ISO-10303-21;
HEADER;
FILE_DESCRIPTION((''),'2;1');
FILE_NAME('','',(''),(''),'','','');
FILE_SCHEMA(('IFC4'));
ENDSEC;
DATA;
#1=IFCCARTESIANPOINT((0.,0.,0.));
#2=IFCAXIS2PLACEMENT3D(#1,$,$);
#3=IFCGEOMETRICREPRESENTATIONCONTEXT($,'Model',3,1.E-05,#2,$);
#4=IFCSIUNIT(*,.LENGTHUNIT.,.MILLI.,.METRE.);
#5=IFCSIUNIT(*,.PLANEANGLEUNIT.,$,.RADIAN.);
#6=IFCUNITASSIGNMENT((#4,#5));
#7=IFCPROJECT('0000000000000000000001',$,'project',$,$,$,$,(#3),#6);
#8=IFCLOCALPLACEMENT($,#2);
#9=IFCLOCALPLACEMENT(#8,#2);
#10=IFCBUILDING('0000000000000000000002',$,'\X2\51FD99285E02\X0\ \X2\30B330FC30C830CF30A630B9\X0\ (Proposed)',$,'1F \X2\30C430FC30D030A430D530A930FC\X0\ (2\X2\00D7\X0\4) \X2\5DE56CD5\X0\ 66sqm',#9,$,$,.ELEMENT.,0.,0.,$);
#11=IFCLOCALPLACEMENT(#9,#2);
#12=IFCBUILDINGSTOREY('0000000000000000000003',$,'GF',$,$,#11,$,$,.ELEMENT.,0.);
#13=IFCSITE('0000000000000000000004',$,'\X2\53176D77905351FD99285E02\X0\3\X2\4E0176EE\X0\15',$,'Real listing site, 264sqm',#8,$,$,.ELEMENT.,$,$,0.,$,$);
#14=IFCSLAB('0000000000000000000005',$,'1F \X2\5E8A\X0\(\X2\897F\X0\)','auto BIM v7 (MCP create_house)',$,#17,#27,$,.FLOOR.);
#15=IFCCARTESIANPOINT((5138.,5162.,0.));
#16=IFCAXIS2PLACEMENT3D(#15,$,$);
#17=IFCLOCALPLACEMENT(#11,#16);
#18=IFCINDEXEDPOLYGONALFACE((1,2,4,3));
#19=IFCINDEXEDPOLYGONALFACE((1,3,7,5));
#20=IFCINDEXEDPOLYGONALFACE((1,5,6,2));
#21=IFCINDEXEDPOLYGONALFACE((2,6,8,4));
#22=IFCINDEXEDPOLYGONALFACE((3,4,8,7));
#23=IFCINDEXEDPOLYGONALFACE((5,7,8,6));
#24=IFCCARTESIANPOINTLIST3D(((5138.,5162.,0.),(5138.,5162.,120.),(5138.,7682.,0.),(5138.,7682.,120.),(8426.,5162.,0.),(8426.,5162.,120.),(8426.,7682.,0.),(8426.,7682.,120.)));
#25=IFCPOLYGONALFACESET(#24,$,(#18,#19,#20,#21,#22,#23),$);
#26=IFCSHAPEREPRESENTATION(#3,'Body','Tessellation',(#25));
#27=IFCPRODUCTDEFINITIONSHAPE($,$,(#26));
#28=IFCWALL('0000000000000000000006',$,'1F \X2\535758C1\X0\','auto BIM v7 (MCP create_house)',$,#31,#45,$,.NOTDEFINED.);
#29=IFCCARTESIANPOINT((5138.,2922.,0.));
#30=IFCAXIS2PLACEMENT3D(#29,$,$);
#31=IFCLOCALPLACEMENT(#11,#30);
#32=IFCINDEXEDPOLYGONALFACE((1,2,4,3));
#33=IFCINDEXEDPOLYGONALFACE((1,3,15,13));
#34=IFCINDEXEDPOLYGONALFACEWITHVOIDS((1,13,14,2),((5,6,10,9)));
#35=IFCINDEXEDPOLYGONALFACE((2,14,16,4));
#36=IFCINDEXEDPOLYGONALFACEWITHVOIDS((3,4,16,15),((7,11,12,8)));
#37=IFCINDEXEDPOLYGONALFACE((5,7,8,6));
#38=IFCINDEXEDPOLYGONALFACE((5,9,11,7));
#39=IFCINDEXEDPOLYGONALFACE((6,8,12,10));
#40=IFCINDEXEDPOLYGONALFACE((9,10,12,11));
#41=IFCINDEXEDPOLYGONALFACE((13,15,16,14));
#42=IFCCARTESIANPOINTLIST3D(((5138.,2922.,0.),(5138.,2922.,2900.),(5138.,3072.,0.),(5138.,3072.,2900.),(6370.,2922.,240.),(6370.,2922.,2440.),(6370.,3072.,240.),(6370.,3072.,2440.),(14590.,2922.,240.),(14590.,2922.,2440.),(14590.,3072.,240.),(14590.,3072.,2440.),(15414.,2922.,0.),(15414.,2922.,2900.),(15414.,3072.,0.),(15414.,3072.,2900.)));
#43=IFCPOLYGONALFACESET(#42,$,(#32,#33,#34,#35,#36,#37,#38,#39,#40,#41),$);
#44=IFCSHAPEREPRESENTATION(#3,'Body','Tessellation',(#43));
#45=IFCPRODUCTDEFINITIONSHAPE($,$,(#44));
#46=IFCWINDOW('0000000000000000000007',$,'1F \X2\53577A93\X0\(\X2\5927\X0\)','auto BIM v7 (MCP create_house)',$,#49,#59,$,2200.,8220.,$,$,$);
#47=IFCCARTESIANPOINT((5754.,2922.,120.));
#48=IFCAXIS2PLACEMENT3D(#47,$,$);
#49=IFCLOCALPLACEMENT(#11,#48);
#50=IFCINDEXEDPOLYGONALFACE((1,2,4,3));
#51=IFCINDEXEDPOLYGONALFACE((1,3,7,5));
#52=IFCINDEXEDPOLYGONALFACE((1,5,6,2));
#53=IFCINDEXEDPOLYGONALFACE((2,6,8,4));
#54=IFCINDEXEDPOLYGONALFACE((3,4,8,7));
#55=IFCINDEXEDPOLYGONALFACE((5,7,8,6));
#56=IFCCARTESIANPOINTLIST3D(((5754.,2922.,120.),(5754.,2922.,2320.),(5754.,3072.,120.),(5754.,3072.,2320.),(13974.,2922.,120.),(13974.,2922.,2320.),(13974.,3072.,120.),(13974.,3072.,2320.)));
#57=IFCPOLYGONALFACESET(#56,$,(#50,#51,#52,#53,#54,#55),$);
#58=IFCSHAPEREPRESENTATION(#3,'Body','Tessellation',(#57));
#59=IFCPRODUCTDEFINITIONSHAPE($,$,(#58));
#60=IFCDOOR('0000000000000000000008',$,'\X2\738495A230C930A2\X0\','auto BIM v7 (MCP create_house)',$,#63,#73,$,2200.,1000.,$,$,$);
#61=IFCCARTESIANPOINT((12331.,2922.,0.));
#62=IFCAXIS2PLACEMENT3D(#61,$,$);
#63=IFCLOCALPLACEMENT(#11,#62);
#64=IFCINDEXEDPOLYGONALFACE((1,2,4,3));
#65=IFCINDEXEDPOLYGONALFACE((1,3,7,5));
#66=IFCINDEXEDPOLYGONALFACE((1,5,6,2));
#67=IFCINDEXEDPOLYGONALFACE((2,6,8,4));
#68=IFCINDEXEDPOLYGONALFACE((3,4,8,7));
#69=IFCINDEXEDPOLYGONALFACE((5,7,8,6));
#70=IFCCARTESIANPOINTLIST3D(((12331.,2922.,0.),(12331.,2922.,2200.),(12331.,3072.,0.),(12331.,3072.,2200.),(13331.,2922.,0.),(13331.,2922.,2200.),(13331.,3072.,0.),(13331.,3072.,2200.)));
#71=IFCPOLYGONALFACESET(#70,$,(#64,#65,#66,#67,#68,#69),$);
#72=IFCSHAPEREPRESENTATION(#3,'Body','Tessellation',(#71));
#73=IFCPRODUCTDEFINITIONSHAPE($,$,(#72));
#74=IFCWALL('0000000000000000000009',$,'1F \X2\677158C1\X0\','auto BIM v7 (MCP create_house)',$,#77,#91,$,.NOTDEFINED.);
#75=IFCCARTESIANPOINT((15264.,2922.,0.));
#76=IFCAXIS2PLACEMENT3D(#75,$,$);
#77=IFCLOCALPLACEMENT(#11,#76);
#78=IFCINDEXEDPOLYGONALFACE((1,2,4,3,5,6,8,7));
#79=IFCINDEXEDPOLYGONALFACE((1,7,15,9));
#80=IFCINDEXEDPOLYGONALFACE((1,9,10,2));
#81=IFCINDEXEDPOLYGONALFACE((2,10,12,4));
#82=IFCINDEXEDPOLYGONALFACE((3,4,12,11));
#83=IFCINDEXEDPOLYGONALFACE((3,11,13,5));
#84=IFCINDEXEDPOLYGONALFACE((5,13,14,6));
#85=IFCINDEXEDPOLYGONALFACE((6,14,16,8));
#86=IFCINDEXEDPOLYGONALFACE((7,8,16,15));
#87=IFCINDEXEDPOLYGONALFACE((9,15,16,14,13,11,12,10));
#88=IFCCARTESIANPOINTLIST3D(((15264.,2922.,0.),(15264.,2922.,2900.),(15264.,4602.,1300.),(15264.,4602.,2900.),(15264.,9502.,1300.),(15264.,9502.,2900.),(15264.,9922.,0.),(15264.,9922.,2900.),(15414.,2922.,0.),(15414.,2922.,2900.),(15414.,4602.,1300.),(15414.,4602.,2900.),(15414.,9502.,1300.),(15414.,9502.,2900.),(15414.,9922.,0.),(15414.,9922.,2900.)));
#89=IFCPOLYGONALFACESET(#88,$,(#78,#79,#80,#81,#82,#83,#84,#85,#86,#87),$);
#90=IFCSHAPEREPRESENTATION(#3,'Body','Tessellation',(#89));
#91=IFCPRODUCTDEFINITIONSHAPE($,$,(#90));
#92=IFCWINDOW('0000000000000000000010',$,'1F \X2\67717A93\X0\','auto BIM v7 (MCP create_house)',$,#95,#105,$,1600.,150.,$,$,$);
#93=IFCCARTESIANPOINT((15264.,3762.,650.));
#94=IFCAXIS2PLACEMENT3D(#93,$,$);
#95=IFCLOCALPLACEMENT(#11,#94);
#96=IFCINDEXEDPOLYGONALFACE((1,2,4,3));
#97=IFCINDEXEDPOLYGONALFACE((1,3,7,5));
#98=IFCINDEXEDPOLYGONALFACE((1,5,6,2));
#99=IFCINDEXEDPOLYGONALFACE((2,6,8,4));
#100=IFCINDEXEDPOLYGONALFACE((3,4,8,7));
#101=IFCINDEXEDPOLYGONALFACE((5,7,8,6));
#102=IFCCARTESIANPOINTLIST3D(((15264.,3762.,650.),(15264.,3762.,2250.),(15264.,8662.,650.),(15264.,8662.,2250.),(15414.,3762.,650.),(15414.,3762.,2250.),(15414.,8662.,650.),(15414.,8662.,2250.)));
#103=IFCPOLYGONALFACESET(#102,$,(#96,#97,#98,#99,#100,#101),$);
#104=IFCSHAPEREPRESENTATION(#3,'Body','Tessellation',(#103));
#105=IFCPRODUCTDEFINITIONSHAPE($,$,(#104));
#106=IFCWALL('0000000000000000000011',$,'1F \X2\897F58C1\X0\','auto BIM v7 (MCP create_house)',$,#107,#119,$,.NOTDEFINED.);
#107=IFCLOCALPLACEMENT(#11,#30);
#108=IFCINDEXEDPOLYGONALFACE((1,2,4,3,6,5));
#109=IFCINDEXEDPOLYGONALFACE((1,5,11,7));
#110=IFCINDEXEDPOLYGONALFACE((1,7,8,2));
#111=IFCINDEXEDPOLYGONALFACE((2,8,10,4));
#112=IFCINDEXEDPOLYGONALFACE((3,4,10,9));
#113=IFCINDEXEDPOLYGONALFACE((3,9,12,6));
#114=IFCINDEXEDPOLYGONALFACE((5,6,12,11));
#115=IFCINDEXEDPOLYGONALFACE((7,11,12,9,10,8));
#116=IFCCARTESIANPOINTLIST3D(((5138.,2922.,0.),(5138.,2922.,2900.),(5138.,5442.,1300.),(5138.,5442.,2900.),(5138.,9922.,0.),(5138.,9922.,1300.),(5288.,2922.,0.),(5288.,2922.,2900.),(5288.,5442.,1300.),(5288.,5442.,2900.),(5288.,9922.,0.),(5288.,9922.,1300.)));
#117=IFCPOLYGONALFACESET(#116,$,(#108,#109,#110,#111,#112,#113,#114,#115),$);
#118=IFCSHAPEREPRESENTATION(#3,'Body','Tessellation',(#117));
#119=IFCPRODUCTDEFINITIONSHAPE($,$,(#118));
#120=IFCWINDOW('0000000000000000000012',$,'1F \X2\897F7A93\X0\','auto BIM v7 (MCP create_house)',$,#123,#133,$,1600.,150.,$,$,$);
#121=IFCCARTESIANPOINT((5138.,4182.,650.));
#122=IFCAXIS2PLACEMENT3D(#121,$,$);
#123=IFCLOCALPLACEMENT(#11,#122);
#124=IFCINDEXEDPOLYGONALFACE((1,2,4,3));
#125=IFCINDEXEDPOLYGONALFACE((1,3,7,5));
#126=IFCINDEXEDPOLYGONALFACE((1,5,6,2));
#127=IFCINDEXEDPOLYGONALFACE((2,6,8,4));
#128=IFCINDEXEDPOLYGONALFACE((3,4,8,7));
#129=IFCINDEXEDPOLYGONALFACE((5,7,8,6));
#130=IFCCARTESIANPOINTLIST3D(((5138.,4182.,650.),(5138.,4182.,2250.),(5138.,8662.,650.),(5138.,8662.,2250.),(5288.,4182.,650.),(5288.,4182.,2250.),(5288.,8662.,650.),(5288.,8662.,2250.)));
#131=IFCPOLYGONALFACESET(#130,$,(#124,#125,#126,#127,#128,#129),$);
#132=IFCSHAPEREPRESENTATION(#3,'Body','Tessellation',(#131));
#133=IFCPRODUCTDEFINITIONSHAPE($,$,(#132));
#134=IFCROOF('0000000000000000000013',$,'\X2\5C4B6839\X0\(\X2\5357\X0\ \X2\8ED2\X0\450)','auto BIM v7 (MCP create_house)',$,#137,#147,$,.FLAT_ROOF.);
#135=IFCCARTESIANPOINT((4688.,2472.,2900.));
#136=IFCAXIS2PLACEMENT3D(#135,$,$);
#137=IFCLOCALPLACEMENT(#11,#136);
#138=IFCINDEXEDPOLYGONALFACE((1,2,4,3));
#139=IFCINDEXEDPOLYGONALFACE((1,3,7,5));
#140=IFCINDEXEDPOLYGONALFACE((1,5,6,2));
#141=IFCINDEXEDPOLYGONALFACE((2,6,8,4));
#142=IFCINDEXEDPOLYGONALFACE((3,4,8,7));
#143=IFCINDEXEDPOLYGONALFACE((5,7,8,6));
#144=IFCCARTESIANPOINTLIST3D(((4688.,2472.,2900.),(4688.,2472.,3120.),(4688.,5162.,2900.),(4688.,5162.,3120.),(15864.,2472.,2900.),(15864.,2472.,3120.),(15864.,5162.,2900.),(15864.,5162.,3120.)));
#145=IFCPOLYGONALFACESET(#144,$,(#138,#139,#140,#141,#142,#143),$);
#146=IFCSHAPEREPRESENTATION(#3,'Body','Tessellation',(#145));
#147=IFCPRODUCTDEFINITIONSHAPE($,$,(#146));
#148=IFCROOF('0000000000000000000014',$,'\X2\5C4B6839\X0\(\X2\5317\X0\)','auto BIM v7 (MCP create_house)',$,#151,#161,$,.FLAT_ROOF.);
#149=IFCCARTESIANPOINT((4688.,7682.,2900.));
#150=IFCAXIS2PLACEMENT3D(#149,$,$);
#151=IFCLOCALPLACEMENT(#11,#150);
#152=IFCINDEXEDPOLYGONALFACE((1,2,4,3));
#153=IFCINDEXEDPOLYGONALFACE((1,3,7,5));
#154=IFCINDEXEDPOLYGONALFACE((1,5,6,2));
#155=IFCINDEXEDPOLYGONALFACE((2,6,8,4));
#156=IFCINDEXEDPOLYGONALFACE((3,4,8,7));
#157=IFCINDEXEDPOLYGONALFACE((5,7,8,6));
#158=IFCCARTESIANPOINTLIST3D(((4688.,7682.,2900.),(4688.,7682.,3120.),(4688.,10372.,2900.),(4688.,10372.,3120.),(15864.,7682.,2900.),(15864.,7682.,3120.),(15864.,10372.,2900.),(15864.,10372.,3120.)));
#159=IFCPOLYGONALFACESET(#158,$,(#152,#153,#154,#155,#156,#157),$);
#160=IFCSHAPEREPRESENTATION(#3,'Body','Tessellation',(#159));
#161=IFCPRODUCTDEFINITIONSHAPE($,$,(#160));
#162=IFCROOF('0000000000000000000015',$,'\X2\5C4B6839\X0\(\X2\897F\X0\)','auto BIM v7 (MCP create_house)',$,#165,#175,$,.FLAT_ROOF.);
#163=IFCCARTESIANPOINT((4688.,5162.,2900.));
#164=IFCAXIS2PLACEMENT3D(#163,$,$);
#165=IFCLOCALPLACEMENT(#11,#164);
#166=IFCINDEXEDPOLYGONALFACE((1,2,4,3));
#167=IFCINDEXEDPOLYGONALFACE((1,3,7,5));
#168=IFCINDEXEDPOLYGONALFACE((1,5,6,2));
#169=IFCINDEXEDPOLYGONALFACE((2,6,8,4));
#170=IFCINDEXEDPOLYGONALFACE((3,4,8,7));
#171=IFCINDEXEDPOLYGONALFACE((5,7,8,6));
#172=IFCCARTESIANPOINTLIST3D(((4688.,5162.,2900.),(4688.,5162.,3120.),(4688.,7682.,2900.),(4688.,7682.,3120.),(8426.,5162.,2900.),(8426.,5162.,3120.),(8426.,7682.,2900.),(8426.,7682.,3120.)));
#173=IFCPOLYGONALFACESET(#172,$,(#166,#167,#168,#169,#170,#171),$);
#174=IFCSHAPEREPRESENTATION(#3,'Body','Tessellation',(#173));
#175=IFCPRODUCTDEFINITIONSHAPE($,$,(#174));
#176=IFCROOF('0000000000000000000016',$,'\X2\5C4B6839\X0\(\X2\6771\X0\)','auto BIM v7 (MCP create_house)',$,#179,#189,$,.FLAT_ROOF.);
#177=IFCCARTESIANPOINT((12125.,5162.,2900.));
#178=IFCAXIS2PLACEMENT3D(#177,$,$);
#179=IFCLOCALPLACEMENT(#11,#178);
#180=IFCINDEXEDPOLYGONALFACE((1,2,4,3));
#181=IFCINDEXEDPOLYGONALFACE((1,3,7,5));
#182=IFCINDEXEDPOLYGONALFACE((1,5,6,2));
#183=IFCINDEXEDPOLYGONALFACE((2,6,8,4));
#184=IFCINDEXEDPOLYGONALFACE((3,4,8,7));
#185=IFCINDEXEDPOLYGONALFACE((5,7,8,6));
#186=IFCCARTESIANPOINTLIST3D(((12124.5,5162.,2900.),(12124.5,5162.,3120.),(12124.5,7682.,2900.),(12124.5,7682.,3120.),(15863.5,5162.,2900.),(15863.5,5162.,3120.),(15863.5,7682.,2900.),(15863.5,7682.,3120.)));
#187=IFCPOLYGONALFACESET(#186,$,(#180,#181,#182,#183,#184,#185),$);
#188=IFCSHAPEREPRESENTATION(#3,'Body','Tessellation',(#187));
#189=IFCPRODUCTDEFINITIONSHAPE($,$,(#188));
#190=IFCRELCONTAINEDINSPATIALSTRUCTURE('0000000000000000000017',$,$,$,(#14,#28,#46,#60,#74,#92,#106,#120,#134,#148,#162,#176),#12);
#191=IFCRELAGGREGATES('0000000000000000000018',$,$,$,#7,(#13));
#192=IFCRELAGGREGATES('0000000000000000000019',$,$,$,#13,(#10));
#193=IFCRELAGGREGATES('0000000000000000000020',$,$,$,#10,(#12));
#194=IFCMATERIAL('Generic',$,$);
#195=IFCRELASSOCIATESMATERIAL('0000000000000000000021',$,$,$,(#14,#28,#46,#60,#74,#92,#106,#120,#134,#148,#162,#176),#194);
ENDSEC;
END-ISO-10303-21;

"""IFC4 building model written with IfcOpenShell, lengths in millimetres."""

from ifc_helpers import new_model, si_unit, frame, frame_2d, origin, place, context, project, spatial, rectangle, extrude, material, element, fill, save


model = new_model("IFC4")

# Units and contexts
model_context = context("Model", 3, precision=1e-05, world=origin())
ifc_project = project(units=[si_unit("LENGTHUNIT", "METRE", prefix="MILLI"), si_unit("PLANEANGLEUNIT", "RADIAN")], contexts=[model_context])

# Site, building, storey
site_placement = place(None, origin())
site = spatial("IfcSite", under=ifc_project, at=site_placement, Name="北海道函館市3丁目15", ObjectType="Real listing site, 264sqm", CompositionType="ELEMENT", RefElevation=0.0)
building_placement = place(site_placement, origin())
building = spatial("IfcBuilding", under=site, at=building_placement, Name="函館市 コートハウス (Proposed)", ObjectType="1F ツーバイフォー (2×4) 工法 66sqm", CompositionType="ELEMENT", ElevationOfRefHeight=0.0, ElevationOfTerrain=0.0)
storey_placement = place(building_placement, origin())
storey = spatial("IfcBuildingStorey", under=building, at=storey_placement, Name="GF", CompositionType="ELEMENT", Elevation=0.0)

# Slab
ifc_material = material(Name="Generic")
slab_1_placement = place(storey_placement, frame((5138.0, 5162.0, 0.0)))
element("IfcSlab", 1, at=slab_1_placement, inside=storey, material=ifc_material, Name="1F 床(西)", Description="auto BIM v7 (MCP create_house)", PredefinedType="FLOOR", context=model_context, shape_type="SweptSolid", body=[
    extrude(rectangle(XDim=3288.0, YDim=2520.0, at=frame_2d((1644.0, 1260.0))), frame((5138.0, 5162.0, 0.0)), (0.0, 0.0, 1.0), 120.0),
])

# Wall, openings, window, door
wall_1_placement = place(storey_placement, frame((5138.0, 2922.0, 0.0)))
wall_1 = element("IfcWall", 2, at=wall_1_placement, inside=storey, material=ifc_material, Name="1F 南壁", Description="auto BIM v7 (MCP create_house)", PredefinedType="NOTDEFINED", context=model_context, shape_type="SweptSolid", body=[
    extrude(rectangle(XDim=10276.0, YDim=150.0, at=frame_2d((5138.0, 75.0))), frame((5138.0, 2922.0, 0.0)), (0.0, 0.0, 1.0), 2900.0),
])
opening_1_placement = place(storey_placement, frame((5754.0, 2922.0, 120.0)))
opening_1 = element("IfcOpeningElement", 3, at=opening_1_placement, cuts=wall_1, PredefinedType="NOTDEFINED", context=model_context, shape_type="SweptSolid", body=[
    extrude(rectangle(XDim=8220.0, YDim=150.0, at=frame_2d((4110.0, 75.0))), frame((5754.0, 2922.0, 120.0)), (0.0, 0.0, 1.0), 2200.0),
])
opening_2_placement = place(storey_placement, frame((12331.0, 2922.0, 0.0)))
opening_2 = element("IfcOpeningElement", 4, at=opening_2_placement, cuts=wall_1, PredefinedType="NOTDEFINED", context=model_context, shape_type="SweptSolid", body=[
    extrude(rectangle(XDim=1000.0, YDim=150.0, at=frame_2d((500.0, 75.0))), frame((12331.0, 2922.0, 0.0)), (0.0, 0.0, 1.0), 2200.0),
])
window_1_placement = place(storey_placement, frame((5754.0, 2922.0, 120.0)))
window_1 = element("IfcWindow", 5, at=window_1_placement, inside=storey, material=ifc_material, Name="1F 南窓(大)", Description="auto BIM v7 (MCP create_house)", OverallHeight=2200.0, OverallWidth=8220.0, context=model_context, shape_type="SweptSolid", body=[
    extrude(rectangle(XDim=8220.0, YDim=150.0, at=frame_2d((4110.0, 75.0))), frame((5754.0, 2922.0, 120.0)), (0.0, 0.0, 1.0), 2200.0),
])
fill(opening_1, window_1)
door_placement = place(storey_placement, frame((12331.0, 2922.0, 0.0)))
door = element("IfcDoor", 6, at=door_placement, inside=storey, material=ifc_material, Name="玄関ドア", Description="auto BIM v7 (MCP create_house)", OverallHeight=2200.0, OverallWidth=1000.0, context=model_context, shape_type="SweptSolid", body=[
    extrude(rectangle(XDim=1000.0, YDim=150.0, at=frame_2d((500.0, 75.0))), frame((12331.0, 2922.0, 0.0)), (0.0, 0.0, 1.0), 2200.0),
])
fill(opening_2, door)

# Walls, openings, windows
wall_2_placement = place(storey_placement, frame((15264.0, 2922.0, 0.0)))
wall_2 = element("IfcWall", 7, at=wall_2_placement, inside=storey, material=ifc_material, Name="1F 東壁", Description="auto BIM v7 (MCP create_house)", PredefinedType="NOTDEFINED", context=model_context, shape_type="SweptSolid", body=[
    extrude(rectangle(XDim=150.0, YDim=7000.0, at=frame_2d((75.0, 3500.0))), frame((15264.0, 2922.0, 0.0)), (0.0, 0.0, 1.0), 2900.0),
])
opening_3_placement = place(storey_placement, frame((15264.0, 3762.0, 650.0)))
opening_3 = element("IfcOpeningElement", 8, at=opening_3_placement, cuts=wall_2, PredefinedType="NOTDEFINED", context=model_context, shape_type="SweptSolid", body=[
    extrude(rectangle(XDim=150.0, YDim=4900.0, at=frame_2d((75.0, 2450.0))), frame((15264.0, 3762.0, 650.0)), (0.0, 0.0, 1.0), 1600.0),
])
window_2_placement = place(storey_placement, frame((15264.0, 3762.0, 650.0)))
window_2 = element("IfcWindow", 9, at=window_2_placement, inside=storey, material=ifc_material, Name="1F 東窓", Description="auto BIM v7 (MCP create_house)", OverallHeight=1600.0, OverallWidth=150.0, context=model_context, shape_type="SweptSolid", body=[
    extrude(rectangle(XDim=150.0, YDim=4900.0, at=frame_2d((75.0, 2450.0))), frame((15264.0, 3762.0, 650.0)), (0.0, 0.0, 1.0), 1600.0),
])
fill(opening_3, window_2)
wall_3_placement = place(storey_placement, frame((5138.0, 2922.0, 0.0)))
wall_3 = element("IfcWall", 10, at=wall_3_placement, inside=storey, material=ifc_material, Name="1F 西壁", Description="auto BIM v7 (MCP create_house)", PredefinedType="NOTDEFINED", context=model_context, shape_type="SweptSolid", body=[
    extrude(rectangle(XDim=150.0, YDim=7000.0, at=frame_2d((75.0, 3500.0))), frame((5138.0, 2922.0, 0.0)), (0.0, 0.0, 1.0), 2900.0),
])
opening_4_placement = place(storey_placement, frame((5138.0, 4182.0, 650.0)))
opening_4 = element("IfcOpeningElement", 11, at=opening_4_placement, cuts=wall_3, PredefinedType="NOTDEFINED", context=model_context, shape_type="SweptSolid", body=[
    extrude(rectangle(XDim=150.0, YDim=4480.0, at=frame_2d((75.0, 2240.0))), frame((5138.0, 4182.0, 650.0)), (0.0, 0.0, 1.0), 1600.0),
])
window_3_placement = place(storey_placement, frame((5138.0, 4182.0, 650.0)))
window_3 = element("IfcWindow", 12, at=window_3_placement, inside=storey, material=ifc_material, Name="1F 西窓", Description="auto BIM v7 (MCP create_house)", OverallHeight=1600.0, OverallWidth=150.0, context=model_context, shape_type="SweptSolid", body=[
    extrude(rectangle(XDim=150.0, YDim=4480.0, at=frame_2d((75.0, 2240.0))), frame((5138.0, 4182.0, 650.0)), (0.0, 0.0, 1.0), 1600.0),
])
fill(opening_4, window_3)

# Roofs
roof_1_placement = place(storey_placement, frame((4688.0, 2472.0, 2900.0)))
element("IfcRoof", 13, at=roof_1_placement, inside=storey, material=ifc_material, Name="屋根(南 軒450)", Description="auto BIM v7 (MCP create_house)", PredefinedType="FLAT_ROOF", context=model_context, shape_type="SweptSolid", body=[
    extrude(rectangle(XDim=11176.0, YDim=2690.0, at=frame_2d((5588.0, 1345.0))), frame((4688.0, 2472.0, 2900.0)), (0.0, 0.0, 1.0), 220.0),
])
roof_2_placement = place(storey_placement, frame((4688.0, 7682.0, 2900.0)))
element("IfcRoof", 14, at=roof_2_placement, inside=storey, material=ifc_material, Name="屋根(北)", Description="auto BIM v7 (MCP create_house)", PredefinedType="FLAT_ROOF", context=model_context, shape_type="SweptSolid", body=[
    extrude(rectangle(XDim=11176.0, YDim=2690.0, at=frame_2d((5588.0, 1345.0))), frame((4688.0, 7682.0, 2900.0)), (0.0, 0.0, 1.0), 220.0),
])
roof_3_placement = place(storey_placement, frame((4688.0, 5162.0, 2900.0)))
element("IfcRoof", 15, at=roof_3_placement, inside=storey, material=ifc_material, Name="屋根(西)", Description="auto BIM v7 (MCP create_house)", PredefinedType="FLAT_ROOF", context=model_context, shape_type="SweptSolid", body=[
    extrude(rectangle(XDim=3738.0, YDim=2520.0, at=frame_2d((1869.0, 1260.0))), frame((4688.0, 5162.0, 2900.0)), (0.0, 0.0, 1.0), 220.0),
])
roof_4_placement = place(storey_placement, frame((12125.0, 5162.0, 2900.0)))
element("IfcRoof", 16, at=roof_4_placement, inside=storey, material=ifc_material, Name="屋根(東)", Description="auto BIM v7 (MCP create_house)", PredefinedType="FLAT_ROOF", context=model_context, shape_type="SweptSolid", body=[
    extrude(rectangle(XDim=3739.0, YDim=2520.0, at=frame_2d((1869.0, 1260.0))), frame((12125.0, 5162.0, 2900.0)), (0.0, 0.0, 1.0), 220.0),
])

save(model, "model.ifc")
